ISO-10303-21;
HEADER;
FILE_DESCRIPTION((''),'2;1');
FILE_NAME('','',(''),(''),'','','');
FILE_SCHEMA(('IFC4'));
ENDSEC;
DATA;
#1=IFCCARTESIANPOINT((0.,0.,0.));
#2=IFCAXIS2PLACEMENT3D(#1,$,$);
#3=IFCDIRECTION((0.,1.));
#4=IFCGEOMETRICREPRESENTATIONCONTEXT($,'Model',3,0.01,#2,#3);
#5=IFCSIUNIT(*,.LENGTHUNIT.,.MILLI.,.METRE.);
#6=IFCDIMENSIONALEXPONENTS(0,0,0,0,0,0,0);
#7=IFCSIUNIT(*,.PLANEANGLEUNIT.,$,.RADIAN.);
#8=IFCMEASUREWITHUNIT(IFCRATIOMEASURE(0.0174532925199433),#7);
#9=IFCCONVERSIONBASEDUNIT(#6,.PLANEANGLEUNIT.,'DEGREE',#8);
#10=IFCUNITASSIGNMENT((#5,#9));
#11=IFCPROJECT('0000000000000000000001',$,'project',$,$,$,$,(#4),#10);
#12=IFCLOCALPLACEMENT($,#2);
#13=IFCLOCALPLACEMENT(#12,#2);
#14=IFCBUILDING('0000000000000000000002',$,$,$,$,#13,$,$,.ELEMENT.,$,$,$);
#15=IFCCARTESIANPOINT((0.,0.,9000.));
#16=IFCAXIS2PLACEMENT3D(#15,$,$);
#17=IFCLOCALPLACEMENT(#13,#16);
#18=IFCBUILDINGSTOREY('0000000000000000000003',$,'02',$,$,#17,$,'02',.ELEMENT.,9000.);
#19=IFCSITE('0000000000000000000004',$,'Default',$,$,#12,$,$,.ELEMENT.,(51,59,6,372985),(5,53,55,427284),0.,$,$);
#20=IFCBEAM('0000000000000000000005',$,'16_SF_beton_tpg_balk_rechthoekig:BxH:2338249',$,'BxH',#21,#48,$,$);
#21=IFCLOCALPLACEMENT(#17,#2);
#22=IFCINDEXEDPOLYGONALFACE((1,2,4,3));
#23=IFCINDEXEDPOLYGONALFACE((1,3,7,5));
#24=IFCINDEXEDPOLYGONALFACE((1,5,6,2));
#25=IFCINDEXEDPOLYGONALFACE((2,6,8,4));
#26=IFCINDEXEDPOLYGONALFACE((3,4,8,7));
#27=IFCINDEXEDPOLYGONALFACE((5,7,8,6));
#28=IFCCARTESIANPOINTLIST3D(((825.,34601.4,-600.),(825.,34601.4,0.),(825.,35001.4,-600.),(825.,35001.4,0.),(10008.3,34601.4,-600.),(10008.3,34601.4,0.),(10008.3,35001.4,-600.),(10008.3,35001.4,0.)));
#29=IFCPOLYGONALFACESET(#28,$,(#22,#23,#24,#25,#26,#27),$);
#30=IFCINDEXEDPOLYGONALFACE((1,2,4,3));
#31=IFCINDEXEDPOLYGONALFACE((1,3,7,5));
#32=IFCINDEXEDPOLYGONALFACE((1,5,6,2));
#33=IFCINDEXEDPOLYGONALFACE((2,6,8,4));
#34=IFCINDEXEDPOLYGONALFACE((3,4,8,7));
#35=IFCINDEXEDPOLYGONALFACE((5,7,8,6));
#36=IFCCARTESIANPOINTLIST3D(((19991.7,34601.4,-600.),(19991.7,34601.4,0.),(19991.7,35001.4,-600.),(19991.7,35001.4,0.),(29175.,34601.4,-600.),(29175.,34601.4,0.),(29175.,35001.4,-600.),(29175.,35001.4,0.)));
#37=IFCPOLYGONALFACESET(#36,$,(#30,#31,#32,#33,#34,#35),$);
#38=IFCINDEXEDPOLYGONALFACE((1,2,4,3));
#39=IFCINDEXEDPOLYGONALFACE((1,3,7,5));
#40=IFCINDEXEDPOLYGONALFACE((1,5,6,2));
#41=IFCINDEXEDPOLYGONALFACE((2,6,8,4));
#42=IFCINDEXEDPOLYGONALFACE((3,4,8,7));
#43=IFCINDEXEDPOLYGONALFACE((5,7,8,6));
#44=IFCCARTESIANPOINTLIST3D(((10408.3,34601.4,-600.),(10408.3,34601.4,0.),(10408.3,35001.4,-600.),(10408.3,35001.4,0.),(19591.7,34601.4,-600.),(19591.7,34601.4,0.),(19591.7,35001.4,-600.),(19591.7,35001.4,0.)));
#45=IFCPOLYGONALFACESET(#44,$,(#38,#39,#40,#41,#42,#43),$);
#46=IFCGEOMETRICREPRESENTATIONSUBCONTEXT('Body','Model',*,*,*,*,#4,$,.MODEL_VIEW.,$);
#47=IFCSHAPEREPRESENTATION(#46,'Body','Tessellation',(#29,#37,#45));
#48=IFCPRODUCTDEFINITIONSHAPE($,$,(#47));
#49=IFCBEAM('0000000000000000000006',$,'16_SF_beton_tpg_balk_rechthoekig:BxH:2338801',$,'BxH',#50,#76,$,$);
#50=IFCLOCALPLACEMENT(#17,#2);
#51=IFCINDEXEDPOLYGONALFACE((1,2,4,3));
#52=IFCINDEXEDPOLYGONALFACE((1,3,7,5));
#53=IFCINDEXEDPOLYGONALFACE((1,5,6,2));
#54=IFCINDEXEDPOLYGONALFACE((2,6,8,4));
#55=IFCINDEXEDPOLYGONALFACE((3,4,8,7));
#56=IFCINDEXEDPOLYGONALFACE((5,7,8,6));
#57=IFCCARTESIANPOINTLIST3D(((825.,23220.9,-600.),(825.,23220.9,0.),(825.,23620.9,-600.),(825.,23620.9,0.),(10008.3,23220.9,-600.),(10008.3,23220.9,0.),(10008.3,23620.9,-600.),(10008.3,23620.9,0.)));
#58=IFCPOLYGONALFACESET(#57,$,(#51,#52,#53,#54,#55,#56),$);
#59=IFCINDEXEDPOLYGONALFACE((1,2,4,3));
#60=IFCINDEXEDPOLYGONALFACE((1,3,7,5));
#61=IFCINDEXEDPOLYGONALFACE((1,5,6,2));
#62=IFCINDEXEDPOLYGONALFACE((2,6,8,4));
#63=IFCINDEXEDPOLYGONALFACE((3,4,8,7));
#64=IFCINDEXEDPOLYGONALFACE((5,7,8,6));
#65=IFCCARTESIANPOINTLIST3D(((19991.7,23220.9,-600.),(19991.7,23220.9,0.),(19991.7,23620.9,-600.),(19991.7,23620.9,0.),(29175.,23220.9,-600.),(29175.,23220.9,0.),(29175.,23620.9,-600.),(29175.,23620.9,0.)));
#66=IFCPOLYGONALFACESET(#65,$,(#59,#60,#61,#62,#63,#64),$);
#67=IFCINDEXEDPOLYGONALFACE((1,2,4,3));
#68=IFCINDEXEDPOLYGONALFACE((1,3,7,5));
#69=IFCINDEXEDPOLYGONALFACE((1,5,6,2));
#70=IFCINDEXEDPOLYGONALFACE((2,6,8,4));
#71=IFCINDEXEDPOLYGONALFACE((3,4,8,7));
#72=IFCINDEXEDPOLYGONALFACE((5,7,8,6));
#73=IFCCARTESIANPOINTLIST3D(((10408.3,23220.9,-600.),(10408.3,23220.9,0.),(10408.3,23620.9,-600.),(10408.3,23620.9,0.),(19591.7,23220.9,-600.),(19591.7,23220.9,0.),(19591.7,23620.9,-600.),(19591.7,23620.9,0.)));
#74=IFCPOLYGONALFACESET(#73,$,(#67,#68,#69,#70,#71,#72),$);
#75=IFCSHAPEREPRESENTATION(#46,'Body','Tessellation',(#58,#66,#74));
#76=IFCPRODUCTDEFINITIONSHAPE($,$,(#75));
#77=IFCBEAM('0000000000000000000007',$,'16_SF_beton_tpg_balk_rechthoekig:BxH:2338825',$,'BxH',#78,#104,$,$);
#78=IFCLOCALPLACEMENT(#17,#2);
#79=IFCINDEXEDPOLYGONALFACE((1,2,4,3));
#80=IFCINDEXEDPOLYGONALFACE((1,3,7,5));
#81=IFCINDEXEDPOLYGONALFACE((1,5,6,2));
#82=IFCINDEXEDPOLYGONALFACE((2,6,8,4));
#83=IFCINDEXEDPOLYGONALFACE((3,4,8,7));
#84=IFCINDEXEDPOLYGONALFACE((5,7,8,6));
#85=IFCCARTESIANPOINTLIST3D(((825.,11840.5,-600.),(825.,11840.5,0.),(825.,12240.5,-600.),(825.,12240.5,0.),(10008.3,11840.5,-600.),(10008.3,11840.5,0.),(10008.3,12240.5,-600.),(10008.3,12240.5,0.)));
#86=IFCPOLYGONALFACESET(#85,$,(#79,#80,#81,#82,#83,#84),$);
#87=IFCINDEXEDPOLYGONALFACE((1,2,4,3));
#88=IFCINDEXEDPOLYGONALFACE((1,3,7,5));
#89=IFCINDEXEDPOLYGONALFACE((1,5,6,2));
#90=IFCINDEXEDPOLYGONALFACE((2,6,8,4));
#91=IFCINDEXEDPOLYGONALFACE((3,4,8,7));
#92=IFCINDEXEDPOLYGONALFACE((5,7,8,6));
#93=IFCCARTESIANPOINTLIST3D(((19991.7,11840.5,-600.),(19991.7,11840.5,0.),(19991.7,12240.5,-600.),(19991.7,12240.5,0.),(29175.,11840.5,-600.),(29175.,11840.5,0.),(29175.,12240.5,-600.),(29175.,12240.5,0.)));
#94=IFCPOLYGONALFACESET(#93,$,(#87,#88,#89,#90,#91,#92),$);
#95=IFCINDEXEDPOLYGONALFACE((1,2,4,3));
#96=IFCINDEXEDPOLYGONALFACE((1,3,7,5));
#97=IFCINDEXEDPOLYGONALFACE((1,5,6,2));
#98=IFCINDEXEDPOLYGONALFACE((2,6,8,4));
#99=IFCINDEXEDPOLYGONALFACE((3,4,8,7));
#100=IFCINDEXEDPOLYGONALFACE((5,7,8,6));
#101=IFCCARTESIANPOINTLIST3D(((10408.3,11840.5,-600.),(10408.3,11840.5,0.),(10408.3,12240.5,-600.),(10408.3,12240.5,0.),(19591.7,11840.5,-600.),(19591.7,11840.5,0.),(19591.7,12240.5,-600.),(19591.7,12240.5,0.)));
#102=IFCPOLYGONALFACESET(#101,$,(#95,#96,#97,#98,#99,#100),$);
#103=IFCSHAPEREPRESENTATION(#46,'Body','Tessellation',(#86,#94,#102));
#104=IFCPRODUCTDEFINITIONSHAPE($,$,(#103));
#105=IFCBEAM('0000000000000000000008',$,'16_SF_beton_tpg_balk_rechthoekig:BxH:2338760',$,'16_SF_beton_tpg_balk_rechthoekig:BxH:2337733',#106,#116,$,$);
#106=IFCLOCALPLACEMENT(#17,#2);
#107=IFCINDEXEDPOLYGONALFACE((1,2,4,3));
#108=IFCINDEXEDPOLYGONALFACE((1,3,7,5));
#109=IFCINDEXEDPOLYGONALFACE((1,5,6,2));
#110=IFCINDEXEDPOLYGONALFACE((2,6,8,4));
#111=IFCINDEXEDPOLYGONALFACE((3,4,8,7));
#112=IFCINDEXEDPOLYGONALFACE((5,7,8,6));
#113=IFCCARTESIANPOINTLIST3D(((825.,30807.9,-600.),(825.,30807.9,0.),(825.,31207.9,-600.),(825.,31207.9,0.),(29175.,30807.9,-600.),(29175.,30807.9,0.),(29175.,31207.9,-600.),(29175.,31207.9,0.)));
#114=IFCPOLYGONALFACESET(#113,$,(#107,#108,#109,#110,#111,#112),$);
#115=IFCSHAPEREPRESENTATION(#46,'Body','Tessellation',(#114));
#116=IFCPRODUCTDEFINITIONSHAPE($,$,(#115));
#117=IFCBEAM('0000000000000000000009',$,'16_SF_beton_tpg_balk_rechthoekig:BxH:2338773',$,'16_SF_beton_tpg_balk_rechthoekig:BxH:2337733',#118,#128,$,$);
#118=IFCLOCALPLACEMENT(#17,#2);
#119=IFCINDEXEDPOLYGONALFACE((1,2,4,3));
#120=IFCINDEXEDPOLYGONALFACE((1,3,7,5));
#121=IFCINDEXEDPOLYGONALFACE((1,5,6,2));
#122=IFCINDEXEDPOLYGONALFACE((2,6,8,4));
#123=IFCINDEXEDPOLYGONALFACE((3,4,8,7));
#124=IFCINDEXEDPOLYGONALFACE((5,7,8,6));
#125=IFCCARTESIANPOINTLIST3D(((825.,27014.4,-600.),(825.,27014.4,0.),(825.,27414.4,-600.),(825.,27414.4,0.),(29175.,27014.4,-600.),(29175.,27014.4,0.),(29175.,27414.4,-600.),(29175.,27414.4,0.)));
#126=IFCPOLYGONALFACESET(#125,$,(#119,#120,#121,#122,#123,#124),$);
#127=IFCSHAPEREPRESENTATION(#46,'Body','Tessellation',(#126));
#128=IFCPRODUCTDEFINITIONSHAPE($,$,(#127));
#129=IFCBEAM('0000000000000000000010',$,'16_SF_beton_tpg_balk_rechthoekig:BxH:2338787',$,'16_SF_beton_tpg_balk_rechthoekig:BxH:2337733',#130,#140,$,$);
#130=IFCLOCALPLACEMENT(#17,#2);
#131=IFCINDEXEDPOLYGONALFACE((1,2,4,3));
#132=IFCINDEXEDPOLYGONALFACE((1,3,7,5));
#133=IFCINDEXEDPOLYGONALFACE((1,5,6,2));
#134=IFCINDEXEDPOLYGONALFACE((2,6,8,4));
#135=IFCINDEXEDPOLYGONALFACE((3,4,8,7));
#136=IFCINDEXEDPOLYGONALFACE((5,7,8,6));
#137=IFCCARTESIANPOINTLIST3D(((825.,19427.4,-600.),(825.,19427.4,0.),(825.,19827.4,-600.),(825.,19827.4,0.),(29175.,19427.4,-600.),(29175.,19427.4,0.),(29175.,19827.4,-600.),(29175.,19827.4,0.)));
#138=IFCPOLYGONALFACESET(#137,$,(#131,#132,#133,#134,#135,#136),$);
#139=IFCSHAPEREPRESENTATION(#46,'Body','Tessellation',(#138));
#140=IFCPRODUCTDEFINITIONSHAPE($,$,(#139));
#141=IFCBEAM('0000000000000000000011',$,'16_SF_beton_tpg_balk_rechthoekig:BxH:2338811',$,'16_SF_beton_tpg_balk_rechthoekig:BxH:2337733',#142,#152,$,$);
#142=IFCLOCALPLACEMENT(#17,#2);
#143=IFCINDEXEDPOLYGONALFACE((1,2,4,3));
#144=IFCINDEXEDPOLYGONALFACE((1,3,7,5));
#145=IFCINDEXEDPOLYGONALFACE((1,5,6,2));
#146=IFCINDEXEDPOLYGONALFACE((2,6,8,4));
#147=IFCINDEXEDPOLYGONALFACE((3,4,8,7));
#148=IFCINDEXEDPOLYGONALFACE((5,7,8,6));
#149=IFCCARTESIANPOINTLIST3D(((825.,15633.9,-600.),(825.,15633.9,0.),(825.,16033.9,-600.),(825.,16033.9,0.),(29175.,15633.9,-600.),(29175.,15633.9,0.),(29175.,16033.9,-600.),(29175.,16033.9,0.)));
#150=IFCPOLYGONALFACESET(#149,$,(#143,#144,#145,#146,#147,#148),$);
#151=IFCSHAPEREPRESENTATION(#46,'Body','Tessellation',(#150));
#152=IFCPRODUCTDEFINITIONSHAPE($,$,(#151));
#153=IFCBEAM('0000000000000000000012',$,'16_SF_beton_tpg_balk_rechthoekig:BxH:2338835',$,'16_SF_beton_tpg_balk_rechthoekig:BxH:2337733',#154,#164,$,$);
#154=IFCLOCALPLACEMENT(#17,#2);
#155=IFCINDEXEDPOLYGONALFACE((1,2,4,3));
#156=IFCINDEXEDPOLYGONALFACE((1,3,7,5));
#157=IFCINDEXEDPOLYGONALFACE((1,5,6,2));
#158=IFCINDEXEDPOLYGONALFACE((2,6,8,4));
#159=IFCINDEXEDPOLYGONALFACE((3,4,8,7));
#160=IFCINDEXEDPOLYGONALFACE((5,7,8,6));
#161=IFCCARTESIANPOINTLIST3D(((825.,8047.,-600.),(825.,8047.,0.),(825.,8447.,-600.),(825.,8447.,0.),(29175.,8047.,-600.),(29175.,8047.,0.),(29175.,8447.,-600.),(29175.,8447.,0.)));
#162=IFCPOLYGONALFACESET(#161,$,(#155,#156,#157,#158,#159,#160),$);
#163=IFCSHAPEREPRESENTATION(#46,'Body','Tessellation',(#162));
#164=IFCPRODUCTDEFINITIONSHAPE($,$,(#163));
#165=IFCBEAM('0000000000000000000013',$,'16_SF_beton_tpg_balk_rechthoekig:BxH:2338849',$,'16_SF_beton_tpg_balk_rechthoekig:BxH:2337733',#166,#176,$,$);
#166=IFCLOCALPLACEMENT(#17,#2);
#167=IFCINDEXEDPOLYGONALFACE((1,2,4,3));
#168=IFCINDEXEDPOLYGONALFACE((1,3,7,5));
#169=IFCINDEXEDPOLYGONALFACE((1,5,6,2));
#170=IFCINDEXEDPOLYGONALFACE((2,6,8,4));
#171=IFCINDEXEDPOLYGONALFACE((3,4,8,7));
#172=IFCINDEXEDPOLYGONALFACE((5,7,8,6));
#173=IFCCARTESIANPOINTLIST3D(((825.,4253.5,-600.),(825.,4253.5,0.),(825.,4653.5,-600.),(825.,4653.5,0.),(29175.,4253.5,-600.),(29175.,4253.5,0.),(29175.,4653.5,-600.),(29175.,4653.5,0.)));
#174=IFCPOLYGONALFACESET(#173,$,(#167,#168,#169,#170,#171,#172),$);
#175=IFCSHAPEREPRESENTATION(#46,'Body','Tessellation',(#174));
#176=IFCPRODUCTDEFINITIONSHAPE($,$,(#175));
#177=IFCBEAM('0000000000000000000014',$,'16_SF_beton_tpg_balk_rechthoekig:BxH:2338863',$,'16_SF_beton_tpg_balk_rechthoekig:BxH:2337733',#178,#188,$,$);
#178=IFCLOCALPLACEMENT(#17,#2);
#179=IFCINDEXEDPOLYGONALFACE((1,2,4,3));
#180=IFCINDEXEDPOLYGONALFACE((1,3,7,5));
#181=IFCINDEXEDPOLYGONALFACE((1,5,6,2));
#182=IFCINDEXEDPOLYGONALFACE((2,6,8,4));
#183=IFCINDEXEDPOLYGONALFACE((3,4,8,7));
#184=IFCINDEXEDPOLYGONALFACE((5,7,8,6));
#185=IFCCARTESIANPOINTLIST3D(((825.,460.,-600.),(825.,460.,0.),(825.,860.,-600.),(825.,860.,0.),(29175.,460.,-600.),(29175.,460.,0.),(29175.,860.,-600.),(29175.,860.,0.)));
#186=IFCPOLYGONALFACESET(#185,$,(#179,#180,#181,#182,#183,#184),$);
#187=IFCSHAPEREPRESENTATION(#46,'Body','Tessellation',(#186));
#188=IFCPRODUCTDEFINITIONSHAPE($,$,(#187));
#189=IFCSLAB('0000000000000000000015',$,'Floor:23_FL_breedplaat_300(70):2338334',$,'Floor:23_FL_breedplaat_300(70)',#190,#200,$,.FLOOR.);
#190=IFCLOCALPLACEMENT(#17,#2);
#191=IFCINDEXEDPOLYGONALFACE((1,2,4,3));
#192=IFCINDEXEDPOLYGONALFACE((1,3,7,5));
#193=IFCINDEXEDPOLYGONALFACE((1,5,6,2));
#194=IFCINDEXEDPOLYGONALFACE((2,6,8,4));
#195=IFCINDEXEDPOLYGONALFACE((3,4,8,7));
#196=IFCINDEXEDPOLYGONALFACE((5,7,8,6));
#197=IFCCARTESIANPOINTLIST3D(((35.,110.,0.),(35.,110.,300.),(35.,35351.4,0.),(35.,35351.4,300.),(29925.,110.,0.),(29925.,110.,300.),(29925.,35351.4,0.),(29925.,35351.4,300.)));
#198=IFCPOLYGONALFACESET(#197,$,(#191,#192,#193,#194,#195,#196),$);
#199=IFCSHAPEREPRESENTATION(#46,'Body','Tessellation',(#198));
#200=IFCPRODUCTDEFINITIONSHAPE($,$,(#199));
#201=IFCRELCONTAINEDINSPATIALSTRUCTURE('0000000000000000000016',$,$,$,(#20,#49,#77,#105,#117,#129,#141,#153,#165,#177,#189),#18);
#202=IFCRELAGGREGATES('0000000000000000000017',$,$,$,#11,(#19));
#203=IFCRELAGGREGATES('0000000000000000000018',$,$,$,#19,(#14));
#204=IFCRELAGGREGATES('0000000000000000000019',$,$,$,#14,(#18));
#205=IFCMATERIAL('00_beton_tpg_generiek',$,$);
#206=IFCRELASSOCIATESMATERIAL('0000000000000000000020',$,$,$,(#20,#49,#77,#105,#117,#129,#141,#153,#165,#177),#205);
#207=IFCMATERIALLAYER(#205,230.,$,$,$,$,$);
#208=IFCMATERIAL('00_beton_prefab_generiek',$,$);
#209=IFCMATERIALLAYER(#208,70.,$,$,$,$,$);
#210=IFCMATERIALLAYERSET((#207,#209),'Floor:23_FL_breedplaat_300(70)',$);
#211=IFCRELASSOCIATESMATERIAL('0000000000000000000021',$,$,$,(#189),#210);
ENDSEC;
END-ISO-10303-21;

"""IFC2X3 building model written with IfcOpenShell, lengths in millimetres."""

from ifc_helpers import new_model, entity, si_unit, converted_unit, direction, frame, frame_2d, origin, origin_2d_with_axis, place, context, subcontext, project, spatial, rectangle, extrude, source, transform, mapped, material, layer, layer_set, layer_usage, element, save


model = new_model("IFC2X3")

# Units and contexts
model_context = context("Model", 3, precision=0.01, world=origin(), true_north=direction((0.0, 1.0)))
body_context = subcontext(model_context, "Body", "Model", "MODEL_VIEW")
ifc_project = project(units=[si_unit("LENGTHUNIT", "METRE", prefix="MILLI"), converted_unit("PLANEANGLEUNIT", "DEGREE", entity("IfcRatioMeasure", 0.0174532925199433), si_unit("PLANEANGLEUNIT", "RADIAN"), dimensions=[0, 0, 0, 0, 0, 0, 0])], contexts=[model_context])

# Site, building, storey
site_placement = place(None, origin())
site = spatial("IfcSite", under=ifc_project, at=site_placement, Name="Default", CompositionType="ELEMENT", RefLatitude=(51, 59, 6, 372985), RefLongitude=(5, 53, 55, 427284), RefElevation=0.0)
building_placement = place(site_placement, origin())
building = spatial("IfcBuilding", under=site, at=building_placement, CompositionType="ELEMENT")
storey_placement = place(building_placement, frame((0.0, 0.0, 9000.0)))
storey = spatial("IfcBuildingStorey", under=building, at=storey_placement, Name="02", LongName="02", CompositionType="ELEMENT", Elevation=9000.0)

# Beams
ifc_material_1 = material(Name="00_beton_tpg_generiek")
shared_shape_1 = source(origin(), body_context, "Body", "SweptSolid", [
    extrude(rectangle(XDim=9183.3, YDim=400.0, at=origin_2d_with_axis()), frame((5416.7, 34801.4, 8400.0)), (0.0, 0.0, 1.0), 600.0),
    extrude(rectangle(XDim=9183.3, YDim=400.0, at=frame_2d((0.0, 0.0), x_axis=(1.0, 0.0))), frame((24583.3, 34801.4, 8400.0), z_axis=(0.0, 0.0, 1.0), x_axis=(-1.0, 0.0, 0.0)), (0.0, 0.0, 1.0), 600.0),
    extrude(rectangle(XDim=9183.3, YDim=400.0, at=frame_2d((0.0, 0.0), x_axis=(1.0, 0.0))), frame((15000.0, 34801.4, 8400.0)), (0.0, 0.0, 1.0), 600.0),
])
beam_1_placement = place(storey_placement, frame((0.0, 0.0, -9000.0)))
element("IfcBeam", 1, at=beam_1_placement, inside=storey, material=ifc_material_1, Name="16_SF_beton_tpg_balk_rechthoekig:BxH:2338249", ObjectType="BxH", context=body_context, shape_type="MappedRepresentation", body=[
    mapped(shared_shape_1, transform((0.0, 0.0, 0.0), scale=1.0)),
])
shared_shape_2 = source(origin(), body_context, "Body", "SweptSolid", [
    extrude(rectangle(XDim=9183.3, YDim=400.0, at=origin_2d_with_axis()), frame((5416.7, 23420.9, 8400.0)), (0.0, 0.0, 1.0), 600.0),
    extrude(rectangle(XDim=9183.3, YDim=400.0, at=frame_2d((0.0, 0.0), x_axis=(1.0, 0.0))), frame((24583.3, 23420.9, 8400.0), z_axis=(0.0, 0.0, 1.0), x_axis=(-1.0, 0.0, 0.0)), (0.0, 0.0, 1.0), 600.0),
    extrude(rectangle(XDim=9183.3, YDim=400.0, at=origin_2d_with_axis()), frame((15000.0, 23420.9, 8400.0), z_axis=(0.0, 0.0, 1.0), x_axis=(-1.0, 0.0, 0.0)), (0.0, 0.0, 1.0), 600.0),
])
beam_2_placement = place(storey_placement, frame((0.0, 0.0, -9000.0)))
element("IfcBeam", 2, at=beam_2_placement, inside=storey, material=ifc_material_1, Name="16_SF_beton_tpg_balk_rechthoekig:BxH:2338801", ObjectType="BxH", context=body_context, shape_type="MappedRepresentation", body=[
    mapped(shared_shape_2, transform((0.0, 0.0, 0.0), scale=1.0)),
])
shared_shape_3 = source(origin(), body_context, "Body", "SweptSolid", [
    extrude(rectangle(XDim=9183.3, YDim=400.0, at=frame_2d((0.0, 0.0), x_axis=(1.0, 0.0))), frame((5416.7, 12040.5, 8400.0)), (0.0, 0.0, 1.0), 600.0),
    extrude(rectangle(XDim=9183.3, YDim=400.0, at=frame_2d((0.0, 0.0), x_axis=(1.0, 0.0))), frame((24583.3, 12040.5, 8400.0), z_axis=(0.0, 0.0, 1.0), x_axis=(-1.0, 0.0, 0.0)), (0.0, 0.0, 1.0), 600.0),
    extrude(rectangle(XDim=9183.3, YDim=400.0, at=frame_2d((0.0, 0.0), x_axis=(1.0, 0.0))), frame((15000.0, 12040.5, 8400.0)), (0.0, 0.0, 1.0), 600.0),
])
beam_3_placement = place(storey_placement, frame((0.0, 0.0, -9000.0)))
element("IfcBeam", 3, at=beam_3_placement, inside=storey, material=ifc_material_1, Name="16_SF_beton_tpg_balk_rechthoekig:BxH:2338825", ObjectType="BxH", context=body_context, shape_type="MappedRepresentation", body=[
    mapped(shared_shape_3, transform((0.0, 0.0, 0.0), scale=1.0)),
])
beam_4_placement = place(storey_placement, frame((625.0, 31007.9, 0.0)))
element("IfcBeam", 4, at=beam_4_placement, inside=storey, material=ifc_material_1, Name="16_SF_beton_tpg_balk_rechthoekig:BxH:2338760", ObjectType="16_SF_beton_tpg_balk_rechthoekig:BxH:2337733", context=body_context, shape_type="SweptSolid", body=[
    extrude(rectangle(XDim=600.0, YDim=400.0, at=frame_2d((0.0, 0.0), x_axis=(1.0, 0.0))), frame((200.0, 0.0, -300.0), z_axis=(1.0, 0.0, 0.0), x_axis=(0.0, 0.0, -1.0)), (0.0, 0.0, 1.0), 28350.0),
])
beam_5_placement = place(storey_placement, frame((625.0, 27214.4, 0.0)))
element("IfcBeam", 5, at=beam_5_placement, inside=storey, material=ifc_material_1, Name="16_SF_beton_tpg_balk_rechthoekig:BxH:2338773", ObjectType="16_SF_beton_tpg_balk_rechthoekig:BxH:2337733", context=body_context, shape_type="SweptSolid", body=[
    extrude(rectangle(XDim=600.0, YDim=400.0, at=frame_2d((0.0, 0.0), x_axis=(1.0, 0.0))), frame((200.0, 0.0, -300.0), z_axis=(1.0, 0.0, 0.0), x_axis=(0.0, 0.0, -1.0)), (0.0, 0.0, 1.0), 28350.0),
])
for number, where, name in (
    (6, (625.0, 19627.4, 0.0), "16_SF_beton_tpg_balk_rechthoekig:BxH:2338787"),
    (7, (625.0, 15833.9, 0.0), "16_SF_beton_tpg_balk_rechthoekig:BxH:2338811"),
):
    element("IfcBeam", number, at=place(storey_placement, frame(where)), inside=storey, material=ifc_material_1, Name=name, ObjectType="16_SF_beton_tpg_balk_rechthoekig:BxH:2337733", context=body_context, shape_type="SweptSolid", body=[
        extrude(rectangle(XDim=600.0, YDim=400.0, at=frame_2d((0.0, 0.0), x_axis=(1.0, 0.0))), frame((200.0, 0.0, -300.0), z_axis=(1.0, 0.0, 0.0), x_axis=(0.0, 0.0, -1.0)), (0.0, 0.0, 1.0), 28350.0),
    ])
for number, where, name in (
    (8, (625.0, 8247.0, 0.0), "16_SF_beton_tpg_balk_rechthoekig:BxH:2338835"),
    (9, (625.0, 4453.5, 0.0), "16_SF_beton_tpg_balk_rechthoekig:BxH:2338849"),
):
    element("IfcBeam", number, at=place(storey_placement, frame(where)), inside=storey, material=ifc_material_1, Name=name, ObjectType="16_SF_beton_tpg_balk_rechthoekig:BxH:2337733", context=body_context, shape_type="SweptSolid", body=[
        extrude(rectangle(XDim=600.0, YDim=400.0, at=frame_2d((0.0, 0.0), x_axis=(1.0, 0.0))), frame((200.0, 0.0, -300.0), z_axis=(1.0, 0.0, 0.0), x_axis=(0.0, 0.0, -1.0)), (0.0, 0.0, 1.0), 28350.0),
    ])
beam_6_placement = place(storey_placement, frame((625.0, 660.0, 0.0)))
element("IfcBeam", 10, at=beam_6_placement, inside=storey, material=ifc_material_1, Name="16_SF_beton_tpg_balk_rechthoekig:BxH:2338863", ObjectType="16_SF_beton_tpg_balk_rechthoekig:BxH:2337733", context=body_context, shape_type="SweptSolid", body=[
    extrude(rectangle(XDim=600.0, YDim=400.0, at=frame_2d((0.0, 0.0), x_axis=(1.0, 0.0))), frame((200.0, 0.0, -300.0), z_axis=(1.0, 0.0, 0.0), x_axis=(0.0, 0.0, -1.0)), (0.0, 0.0, 1.0), 28350.0),
])

# Slab
ifc_layer_1 = layer(ifc_material_1, 230.0)
ifc_material_2 = material(Name="00_beton_prefab_generiek")
ifc_layer_2 = layer(ifc_material_2, 70.0)
ifc_layer_set = layer_set([ifc_layer_1, ifc_layer_2], Name="Floor:23_FL_breedplaat_300(70)")
ifc_layer_usage = layer_usage(ifc_layer_set, "AXIS3", "POSITIVE", 0.0)
slab_placement = place(storey_placement, origin())
element("IfcSlab", 11, at=slab_placement, inside=storey, material=ifc_layer_usage, Name="Floor:23_FL_breedplaat_300(70):2338334", ObjectType="Floor:23_FL_breedplaat_300(70)", PredefinedType="FLOOR", context=body_context, shape_type="SweptSolid", body=[
    extrude(rectangle(XDim=35241.4, YDim=29890.0, at=origin_2d_with_axis()), frame((14980.0, 17730.7, 300.0), z_axis=(0.0, 0.0, -1.0), x_axis=(0.0, 1.0, 0.0)), (0.0, 0.0, 1.0), 300.0),
])

save(model, "model.ifc")
